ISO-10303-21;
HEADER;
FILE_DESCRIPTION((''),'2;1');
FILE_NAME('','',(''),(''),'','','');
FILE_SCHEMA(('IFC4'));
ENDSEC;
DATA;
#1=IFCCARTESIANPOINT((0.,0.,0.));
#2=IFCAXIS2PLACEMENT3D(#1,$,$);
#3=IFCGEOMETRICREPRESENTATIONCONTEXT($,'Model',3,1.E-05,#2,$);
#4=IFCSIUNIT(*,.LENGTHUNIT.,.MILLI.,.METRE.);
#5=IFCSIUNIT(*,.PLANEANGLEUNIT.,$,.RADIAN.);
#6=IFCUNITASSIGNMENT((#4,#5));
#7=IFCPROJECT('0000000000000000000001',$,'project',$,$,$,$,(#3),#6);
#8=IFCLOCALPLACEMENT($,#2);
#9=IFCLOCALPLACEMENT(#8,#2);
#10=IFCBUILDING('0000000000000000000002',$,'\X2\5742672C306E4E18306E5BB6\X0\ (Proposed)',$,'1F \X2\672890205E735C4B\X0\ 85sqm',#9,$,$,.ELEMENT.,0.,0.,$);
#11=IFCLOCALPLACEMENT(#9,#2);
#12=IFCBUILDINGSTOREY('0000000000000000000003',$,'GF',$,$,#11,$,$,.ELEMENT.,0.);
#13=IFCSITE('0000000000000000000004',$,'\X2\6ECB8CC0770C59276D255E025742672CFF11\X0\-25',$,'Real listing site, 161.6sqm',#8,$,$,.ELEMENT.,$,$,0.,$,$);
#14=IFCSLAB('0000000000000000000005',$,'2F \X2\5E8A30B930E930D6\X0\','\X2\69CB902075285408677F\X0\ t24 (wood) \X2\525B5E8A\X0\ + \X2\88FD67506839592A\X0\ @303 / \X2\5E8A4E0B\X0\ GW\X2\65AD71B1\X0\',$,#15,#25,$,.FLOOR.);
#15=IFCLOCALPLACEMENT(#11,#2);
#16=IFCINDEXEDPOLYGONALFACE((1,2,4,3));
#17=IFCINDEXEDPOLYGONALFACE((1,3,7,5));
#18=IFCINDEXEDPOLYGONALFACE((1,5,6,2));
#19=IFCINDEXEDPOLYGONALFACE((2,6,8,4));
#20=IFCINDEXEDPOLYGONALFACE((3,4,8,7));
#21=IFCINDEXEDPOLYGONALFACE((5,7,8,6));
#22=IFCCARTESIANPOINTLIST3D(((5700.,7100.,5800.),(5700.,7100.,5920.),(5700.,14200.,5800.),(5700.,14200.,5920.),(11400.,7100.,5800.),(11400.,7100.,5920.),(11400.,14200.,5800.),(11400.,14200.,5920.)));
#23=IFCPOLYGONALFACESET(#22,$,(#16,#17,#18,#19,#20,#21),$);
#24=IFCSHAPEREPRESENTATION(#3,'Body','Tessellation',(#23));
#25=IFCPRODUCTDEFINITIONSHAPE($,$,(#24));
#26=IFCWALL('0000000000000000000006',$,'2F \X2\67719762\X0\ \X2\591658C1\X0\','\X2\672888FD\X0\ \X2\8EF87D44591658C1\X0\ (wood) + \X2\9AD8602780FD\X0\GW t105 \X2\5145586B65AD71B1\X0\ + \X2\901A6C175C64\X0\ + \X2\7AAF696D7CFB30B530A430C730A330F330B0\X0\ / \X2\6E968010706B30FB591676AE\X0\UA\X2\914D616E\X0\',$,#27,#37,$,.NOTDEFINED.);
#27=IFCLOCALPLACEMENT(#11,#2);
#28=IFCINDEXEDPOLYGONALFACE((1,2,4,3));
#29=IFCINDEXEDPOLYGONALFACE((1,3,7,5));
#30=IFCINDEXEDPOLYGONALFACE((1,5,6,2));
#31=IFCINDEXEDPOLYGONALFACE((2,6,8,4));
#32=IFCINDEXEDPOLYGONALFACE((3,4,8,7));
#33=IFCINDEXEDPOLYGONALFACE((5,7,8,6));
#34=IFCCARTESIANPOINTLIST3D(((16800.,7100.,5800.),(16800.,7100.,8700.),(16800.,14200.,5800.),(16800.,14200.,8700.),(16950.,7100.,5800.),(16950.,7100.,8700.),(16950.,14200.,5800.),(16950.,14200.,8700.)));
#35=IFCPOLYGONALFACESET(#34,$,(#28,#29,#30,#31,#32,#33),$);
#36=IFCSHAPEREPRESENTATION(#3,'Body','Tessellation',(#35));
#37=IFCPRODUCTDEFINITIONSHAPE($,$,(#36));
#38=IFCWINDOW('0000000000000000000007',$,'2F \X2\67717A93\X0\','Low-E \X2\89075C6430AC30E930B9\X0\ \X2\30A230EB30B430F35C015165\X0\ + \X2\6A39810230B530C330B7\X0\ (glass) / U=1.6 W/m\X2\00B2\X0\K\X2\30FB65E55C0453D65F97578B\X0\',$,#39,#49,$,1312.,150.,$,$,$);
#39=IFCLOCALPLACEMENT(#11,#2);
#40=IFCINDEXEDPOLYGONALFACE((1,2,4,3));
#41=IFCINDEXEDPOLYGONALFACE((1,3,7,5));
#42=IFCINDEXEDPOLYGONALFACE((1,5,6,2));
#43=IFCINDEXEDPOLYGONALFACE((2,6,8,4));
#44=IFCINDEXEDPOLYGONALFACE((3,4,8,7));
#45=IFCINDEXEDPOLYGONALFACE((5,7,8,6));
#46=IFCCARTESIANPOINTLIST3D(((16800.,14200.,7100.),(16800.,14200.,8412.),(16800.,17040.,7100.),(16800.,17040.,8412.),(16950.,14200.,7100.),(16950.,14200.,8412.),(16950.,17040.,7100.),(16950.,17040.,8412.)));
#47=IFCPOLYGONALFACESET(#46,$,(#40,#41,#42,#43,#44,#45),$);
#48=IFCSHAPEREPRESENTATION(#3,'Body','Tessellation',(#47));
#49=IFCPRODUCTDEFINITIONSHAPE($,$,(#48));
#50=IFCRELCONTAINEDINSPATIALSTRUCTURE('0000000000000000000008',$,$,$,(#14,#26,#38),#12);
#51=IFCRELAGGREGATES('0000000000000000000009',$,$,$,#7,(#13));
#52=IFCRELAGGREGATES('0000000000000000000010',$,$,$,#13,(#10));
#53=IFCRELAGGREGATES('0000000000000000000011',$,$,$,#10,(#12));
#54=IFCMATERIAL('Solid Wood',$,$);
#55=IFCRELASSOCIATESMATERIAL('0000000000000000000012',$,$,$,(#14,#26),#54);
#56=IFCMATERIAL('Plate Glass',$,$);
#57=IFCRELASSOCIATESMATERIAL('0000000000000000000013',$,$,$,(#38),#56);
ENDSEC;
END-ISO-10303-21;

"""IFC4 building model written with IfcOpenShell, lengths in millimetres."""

from ifc_helpers import new_model, si_unit, frame, frame_2d, origin, place, context, project, spatial, rectangle, extrude, material, element, fill, save


model = new_model("IFC4")

# Units and contexts
model_context = context("Model", 3, precision=1e-05, world=origin())
ifc_project = project(units=[si_unit("LENGTHUNIT", "METRE", prefix="MILLI"), si_unit("PLANEANGLEUNIT", "RADIAN")], contexts=[model_context])

# Site, building, storey
site_placement = place(None, origin())
site = spatial("IfcSite", under=ifc_project, at=site_placement, Name="滋賀県大津市坂本１-25", ObjectType="Real listing site, 161.6sqm", CompositionType="ELEMENT", RefElevation=0.0)
building_placement = place(site_placement, origin())
building = spatial("IfcBuilding", under=site, at=building_placement, Name="坂本の丘の家 (Proposed)", ObjectType="1F 木造平屋 85sqm", CompositionType="ELEMENT", ElevationOfRefHeight=0.0, ElevationOfTerrain=0.0)
storey_placement = place(building_placement, origin())
storey = spatial("IfcBuildingStorey", under=building, at=storey_placement, Name="GF", CompositionType="ELEMENT", Elevation=0.0)

# Slab
ifc_material_1 = material(Name="Solid Wood")
slab_placement = place(storey_placement, frame((2850.0, 3550.0, 2900.0)))
element("IfcSlab", 1, at=slab_placement, inside=storey, material=ifc_material_1, Name="2F 床スラブ", Description="構造用合板 t24 (wood) 剛床 + 製材根太 @303 / 床下 GW断熱", PredefinedType="FLOOR", context=model_context, shape_type="SweptSolid", body=[
    extrude(rectangle(XDim=5700.0, YDim=7100.0, at=frame_2d((2850.0, 3550.0))), frame((2850.0, 3550.0, 2900.0)), (0.0, 0.0, 1.0), 120.0),
])

# Shared definitions
ifc_material_2 = material(Name="Plate Glass")

# Wall, opening, window
wall_1_placement = place(storey_placement, frame((8400.0, 3550.0, 2900.0)))
wall_1 = element("IfcWall", 2, at=wall_1_placement, inside=storey, material=ifc_material_1, Name="2F 東面 外壁", Description="木製 軸組外壁 (wood) + 高性能GW t105 充填断熱 + 通気層 + 窯業系サイディング / 準耐火・外皮UA配慮", PredefinedType="NOTDEFINED", context=model_context, shape_type="SweptSolid", body=[
    extrude(rectangle(XDim=150.0, YDim=7100.0, at=frame_2d((75.0, 3550.0))), frame((8400.0, 3550.0, 2900.0)), (0.0, 0.0, 1.0), 2900.0),
])
opening_1_placement = place(storey_placement, frame((8400.0, 7100.0, 3550.0)))
opening_1 = element("IfcOpeningElement", 3, at=opening_1_placement, cuts=wall_1, PredefinedType="NOTDEFINED", context=model_context, shape_type="SweptSolid", body=[
    extrude(rectangle(XDim=150.0, YDim=2840.0, at=frame_2d((75.0, 1420.0))), frame((8400.0, 7100.0, 3550.0)), (0.0, 0.0, 1.0), 1312.0),
])
window_1_placement = place(storey_placement, frame((8400.0, 7100.0, 3550.0)))
window_1 = element("IfcWindow", 4, at=window_1_placement, inside=storey, material=ifc_material_2, Name="2F 東窓", Description="Low-E 複層ガラス アルゴン封入 + 樹脂サッシ (glass) / U=1.6 W/m²K・日射取得型", OverallHeight=1312.0, OverallWidth=150.0, context=model_context, shape_type="SweptSolid", body=[
    extrude(rectangle(XDim=150.0, YDim=2840.0, at=frame_2d((75.0, 1420.0))), frame((8400.0, 7100.0, 3550.0)), (0.0, 0.0, 1.0), 1312.0),
])
fill(opening_1, window_1)

save(model, "model.ifc")
